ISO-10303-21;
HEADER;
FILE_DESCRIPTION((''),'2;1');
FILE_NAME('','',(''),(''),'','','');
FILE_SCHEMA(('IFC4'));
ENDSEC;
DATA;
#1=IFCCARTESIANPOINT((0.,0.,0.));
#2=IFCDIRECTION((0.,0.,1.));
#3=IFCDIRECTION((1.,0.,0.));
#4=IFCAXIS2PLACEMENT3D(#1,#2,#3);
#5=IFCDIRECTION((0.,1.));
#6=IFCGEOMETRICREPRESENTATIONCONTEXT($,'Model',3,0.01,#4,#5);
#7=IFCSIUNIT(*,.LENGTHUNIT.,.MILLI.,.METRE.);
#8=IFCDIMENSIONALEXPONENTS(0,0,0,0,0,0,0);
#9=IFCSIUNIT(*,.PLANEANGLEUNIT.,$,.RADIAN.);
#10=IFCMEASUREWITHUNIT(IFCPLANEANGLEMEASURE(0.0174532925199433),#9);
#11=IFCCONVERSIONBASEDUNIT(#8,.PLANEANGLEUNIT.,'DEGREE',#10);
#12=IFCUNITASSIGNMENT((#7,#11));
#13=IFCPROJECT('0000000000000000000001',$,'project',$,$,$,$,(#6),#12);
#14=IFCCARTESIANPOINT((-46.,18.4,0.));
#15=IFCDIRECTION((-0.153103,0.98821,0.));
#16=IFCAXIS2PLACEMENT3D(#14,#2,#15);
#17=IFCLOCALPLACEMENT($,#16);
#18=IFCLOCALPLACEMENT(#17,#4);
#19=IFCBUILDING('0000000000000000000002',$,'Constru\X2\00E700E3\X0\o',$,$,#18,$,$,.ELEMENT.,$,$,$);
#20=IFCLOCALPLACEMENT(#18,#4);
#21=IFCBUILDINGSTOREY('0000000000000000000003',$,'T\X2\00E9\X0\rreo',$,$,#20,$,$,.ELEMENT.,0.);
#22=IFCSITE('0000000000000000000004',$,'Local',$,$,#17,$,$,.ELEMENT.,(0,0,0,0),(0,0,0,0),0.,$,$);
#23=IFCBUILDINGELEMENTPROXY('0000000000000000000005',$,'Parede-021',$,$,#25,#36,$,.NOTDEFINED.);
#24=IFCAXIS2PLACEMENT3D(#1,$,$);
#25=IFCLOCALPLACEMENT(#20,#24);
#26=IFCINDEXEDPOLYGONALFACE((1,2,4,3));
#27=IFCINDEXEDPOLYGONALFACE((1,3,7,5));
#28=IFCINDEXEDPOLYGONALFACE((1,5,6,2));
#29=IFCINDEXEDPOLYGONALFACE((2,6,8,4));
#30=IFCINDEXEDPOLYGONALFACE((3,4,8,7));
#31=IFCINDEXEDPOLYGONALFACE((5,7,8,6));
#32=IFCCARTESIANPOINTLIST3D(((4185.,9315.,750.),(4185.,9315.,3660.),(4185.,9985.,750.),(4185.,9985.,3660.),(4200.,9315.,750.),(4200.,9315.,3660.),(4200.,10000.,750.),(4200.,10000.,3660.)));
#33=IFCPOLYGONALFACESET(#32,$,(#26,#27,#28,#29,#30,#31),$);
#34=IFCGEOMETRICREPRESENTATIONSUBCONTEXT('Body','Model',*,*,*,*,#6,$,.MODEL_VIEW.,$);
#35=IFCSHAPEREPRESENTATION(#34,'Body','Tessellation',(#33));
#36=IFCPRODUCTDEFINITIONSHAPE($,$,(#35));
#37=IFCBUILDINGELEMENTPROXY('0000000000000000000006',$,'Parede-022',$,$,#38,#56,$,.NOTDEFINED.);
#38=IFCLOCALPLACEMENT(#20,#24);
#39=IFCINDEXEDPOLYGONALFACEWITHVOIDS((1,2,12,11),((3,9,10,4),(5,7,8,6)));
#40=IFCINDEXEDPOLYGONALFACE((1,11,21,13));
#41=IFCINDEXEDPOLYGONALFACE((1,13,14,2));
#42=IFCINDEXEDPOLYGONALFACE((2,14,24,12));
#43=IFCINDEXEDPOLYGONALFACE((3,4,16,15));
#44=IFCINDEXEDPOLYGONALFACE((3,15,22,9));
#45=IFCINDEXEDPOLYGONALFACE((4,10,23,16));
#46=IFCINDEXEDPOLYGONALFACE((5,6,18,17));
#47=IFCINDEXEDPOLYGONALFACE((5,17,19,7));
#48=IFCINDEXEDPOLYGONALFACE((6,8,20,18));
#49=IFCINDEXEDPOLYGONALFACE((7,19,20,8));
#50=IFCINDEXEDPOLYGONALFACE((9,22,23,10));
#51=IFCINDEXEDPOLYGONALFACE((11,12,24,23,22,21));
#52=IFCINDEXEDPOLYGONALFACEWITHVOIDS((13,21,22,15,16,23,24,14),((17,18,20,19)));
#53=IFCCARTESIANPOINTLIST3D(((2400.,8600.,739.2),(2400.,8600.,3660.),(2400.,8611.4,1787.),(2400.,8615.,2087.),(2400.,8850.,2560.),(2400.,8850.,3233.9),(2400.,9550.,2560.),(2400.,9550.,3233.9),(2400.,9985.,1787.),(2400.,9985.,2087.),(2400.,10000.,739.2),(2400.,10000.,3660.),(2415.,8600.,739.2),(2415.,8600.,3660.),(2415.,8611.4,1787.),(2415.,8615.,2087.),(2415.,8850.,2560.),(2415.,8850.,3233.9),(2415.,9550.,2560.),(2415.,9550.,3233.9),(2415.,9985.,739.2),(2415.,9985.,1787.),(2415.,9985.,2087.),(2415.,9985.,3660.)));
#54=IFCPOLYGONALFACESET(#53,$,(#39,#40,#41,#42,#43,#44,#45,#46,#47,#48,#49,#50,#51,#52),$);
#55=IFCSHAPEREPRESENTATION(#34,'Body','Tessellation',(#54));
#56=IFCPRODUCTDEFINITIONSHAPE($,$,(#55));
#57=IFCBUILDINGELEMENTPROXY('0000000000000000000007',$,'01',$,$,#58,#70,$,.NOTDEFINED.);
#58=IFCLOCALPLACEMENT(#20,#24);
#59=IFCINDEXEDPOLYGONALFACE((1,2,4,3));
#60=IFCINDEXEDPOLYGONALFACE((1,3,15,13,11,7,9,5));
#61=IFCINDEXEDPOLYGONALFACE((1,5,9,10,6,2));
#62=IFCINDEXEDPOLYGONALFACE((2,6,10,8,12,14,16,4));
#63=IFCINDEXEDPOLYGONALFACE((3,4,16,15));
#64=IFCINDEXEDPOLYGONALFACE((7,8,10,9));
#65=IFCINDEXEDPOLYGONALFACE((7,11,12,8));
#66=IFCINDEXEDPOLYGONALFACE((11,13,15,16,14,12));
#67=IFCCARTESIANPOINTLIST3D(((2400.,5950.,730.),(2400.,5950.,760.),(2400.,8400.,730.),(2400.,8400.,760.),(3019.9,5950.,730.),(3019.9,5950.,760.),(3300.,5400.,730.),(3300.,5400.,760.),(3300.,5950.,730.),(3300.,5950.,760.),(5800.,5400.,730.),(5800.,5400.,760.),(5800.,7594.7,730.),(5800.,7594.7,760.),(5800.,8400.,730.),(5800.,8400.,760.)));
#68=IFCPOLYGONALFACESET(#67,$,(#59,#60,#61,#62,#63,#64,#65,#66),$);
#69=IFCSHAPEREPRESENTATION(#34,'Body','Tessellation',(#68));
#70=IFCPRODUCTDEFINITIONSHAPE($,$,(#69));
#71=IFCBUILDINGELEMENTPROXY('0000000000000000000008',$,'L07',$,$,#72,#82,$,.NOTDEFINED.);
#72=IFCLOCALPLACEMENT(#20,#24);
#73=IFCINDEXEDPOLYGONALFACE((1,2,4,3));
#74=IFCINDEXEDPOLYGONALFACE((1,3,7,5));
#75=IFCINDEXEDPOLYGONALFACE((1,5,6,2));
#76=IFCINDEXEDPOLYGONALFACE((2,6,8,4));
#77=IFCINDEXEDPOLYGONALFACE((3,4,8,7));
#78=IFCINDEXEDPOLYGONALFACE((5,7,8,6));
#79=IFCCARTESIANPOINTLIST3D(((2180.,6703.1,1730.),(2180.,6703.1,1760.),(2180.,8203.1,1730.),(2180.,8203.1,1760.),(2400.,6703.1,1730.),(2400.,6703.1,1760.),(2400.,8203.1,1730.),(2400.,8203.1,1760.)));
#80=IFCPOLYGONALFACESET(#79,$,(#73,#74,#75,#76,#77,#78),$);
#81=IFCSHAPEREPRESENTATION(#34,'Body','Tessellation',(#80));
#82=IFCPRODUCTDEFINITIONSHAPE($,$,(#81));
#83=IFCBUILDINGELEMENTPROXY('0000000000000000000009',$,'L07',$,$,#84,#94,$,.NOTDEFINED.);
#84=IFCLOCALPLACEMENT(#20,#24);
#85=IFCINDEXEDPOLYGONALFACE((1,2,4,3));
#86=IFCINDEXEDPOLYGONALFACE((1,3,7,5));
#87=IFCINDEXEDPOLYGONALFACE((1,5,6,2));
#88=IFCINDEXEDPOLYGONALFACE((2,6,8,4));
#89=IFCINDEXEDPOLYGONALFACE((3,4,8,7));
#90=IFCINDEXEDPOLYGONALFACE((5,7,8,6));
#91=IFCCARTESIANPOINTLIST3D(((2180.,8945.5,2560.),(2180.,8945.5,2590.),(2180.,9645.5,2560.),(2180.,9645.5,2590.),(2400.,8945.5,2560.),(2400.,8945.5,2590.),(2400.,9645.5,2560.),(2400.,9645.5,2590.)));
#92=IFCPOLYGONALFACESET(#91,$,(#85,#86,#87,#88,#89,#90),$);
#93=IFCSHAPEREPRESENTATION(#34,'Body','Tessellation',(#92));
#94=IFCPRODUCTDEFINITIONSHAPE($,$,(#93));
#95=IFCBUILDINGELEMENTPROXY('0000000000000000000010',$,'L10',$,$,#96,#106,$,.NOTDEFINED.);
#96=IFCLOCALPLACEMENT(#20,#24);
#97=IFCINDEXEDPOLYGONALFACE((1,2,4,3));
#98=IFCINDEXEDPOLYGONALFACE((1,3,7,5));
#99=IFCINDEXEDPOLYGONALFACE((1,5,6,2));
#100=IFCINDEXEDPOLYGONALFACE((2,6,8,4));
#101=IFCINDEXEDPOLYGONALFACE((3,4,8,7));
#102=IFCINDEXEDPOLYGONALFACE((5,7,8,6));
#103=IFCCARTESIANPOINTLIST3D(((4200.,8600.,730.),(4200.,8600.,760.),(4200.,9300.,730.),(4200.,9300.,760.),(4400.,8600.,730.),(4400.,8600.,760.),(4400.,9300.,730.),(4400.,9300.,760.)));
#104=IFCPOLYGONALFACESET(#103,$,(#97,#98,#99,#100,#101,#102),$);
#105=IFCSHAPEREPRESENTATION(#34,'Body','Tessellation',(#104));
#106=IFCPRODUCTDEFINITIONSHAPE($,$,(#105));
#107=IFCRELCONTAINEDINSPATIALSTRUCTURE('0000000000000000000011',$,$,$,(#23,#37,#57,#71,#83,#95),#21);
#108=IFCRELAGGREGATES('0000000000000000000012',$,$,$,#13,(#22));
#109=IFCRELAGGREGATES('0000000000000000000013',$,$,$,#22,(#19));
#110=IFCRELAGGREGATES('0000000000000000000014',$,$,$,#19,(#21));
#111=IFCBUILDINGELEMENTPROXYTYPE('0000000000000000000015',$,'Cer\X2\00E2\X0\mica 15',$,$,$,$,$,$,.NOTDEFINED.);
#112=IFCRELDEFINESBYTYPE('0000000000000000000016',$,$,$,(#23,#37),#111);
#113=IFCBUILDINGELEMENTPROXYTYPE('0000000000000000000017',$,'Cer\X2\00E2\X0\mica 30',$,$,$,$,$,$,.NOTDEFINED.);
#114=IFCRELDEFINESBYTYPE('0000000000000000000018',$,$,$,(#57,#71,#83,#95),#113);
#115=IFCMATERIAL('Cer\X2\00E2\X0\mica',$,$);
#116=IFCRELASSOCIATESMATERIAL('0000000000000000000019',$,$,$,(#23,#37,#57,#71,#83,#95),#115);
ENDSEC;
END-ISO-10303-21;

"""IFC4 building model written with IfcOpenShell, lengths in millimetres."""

from ifc_helpers import new_model, entity, si_unit, converted_unit, direction, frame, origin_with_axes, origin_2d_with_axis, place, context, subcontext, project, spatial, line, indexed_curve, rectangle, outline, extrude, material, type_object, element, save


model = new_model("IFC4")

# Units and contexts
model_context = context("Model", 3, precision=0.01, world=origin_with_axes(), true_north=direction((0.0, 1.0)))
body_context = subcontext(model_context, "Body", "Model", "MODEL_VIEW")
ifc_project = project(units=[si_unit("LENGTHUNIT", "METRE", prefix="MILLI"), converted_unit("PLANEANGLEUNIT", "DEGREE", entity("IfcPlaneAngleMeasure", 0.0174532925199433), si_unit("PLANEANGLEUNIT", "RADIAN"), dimensions=[0, 0, 0, 0, 0, 0, 0])], contexts=[model_context])

# Site, building, storey
site_placement = place(None, frame((-46.0, 18.4, 0.0), z_axis=(0.0, 0.0, 1.0), x_axis=(-0.153103, 0.98821, 0.0)))
site = spatial("IfcSite", under=ifc_project, at=site_placement, Name="Local", CompositionType="ELEMENT", RefLatitude=(0, 0, 0, 0), RefLongitude=(0, 0, 0, 0), RefElevation=0.0)
building_placement = place(site_placement, origin_with_axes())
building = spatial("IfcBuilding", under=site, at=building_placement, Name="Construção", CompositionType="ELEMENT")
storey_placement = place(building_placement, origin_with_axes())
storey = spatial("IfcBuildingStorey", under=building, at=storey_placement, Name="Térreo", CompositionType="ELEMENT", Elevation=0.0)

# Building element proxy
ifc_material_1 = material(Name="Cerâmica")
building_element_proxy_type_1 = type_object("IfcBuildingElementProxyType", Name="Cerâmica 15", PredefinedType="NOTDEFINED")
proxy_1_placement = place(storey_placement, frame((4200.0, 9315.0, 750.0), z_axis=(0.0, 0.0, 1.0), x_axis=(-0.000002, 1.0, 0.0)))
element("IfcBuildingElementProxy", 1, at=proxy_1_placement, inside=storey, type_object=building_element_proxy_type_1, material=ifc_material_1, Name="Parede-021", PredefinedType="NOTDEFINED", context=body_context, shape_type="SweptSolid", body=[
    extrude(outline(indexed_curve([(0.0, 0.0), (685.0, 0.0), (670.0, 15.0), (0.0, 15.0)], segments=[line(1, 2, 3, 4, 1)])), origin_with_axes(), (0.0, 0.0, 1.0), 2910.0),
])

# Building element proxy, openings
proxy_2_placement = place(storey_placement, frame((2400.0, 10000.0, 739.2), z_axis=(0.0, 0.0, 1.0), x_axis=(0.0, -1.0, 0.0)))
proxy_2 = element("IfcBuildingElementProxy", 2, at=proxy_2_placement, inside=storey, type_object=building_element_proxy_type_1, material=ifc_material_1, Name="Parede-022", PredefinedType="NOTDEFINED", context=body_context, shape_type="SweptSolid", body=[
    extrude(outline(indexed_curve([(0.0, 0.0), (1400.0, 0.0), (1400.0, 15.0), (15.0, 15.0)], segments=[line(1, 2, 3, 4, 1)])), origin_with_axes(), (0.0, 0.0, 1.0), 2920.8),
])
opening_1_placement = place(proxy_2_placement, frame((10000.0, -2400.0, -739.2), z_axis=(0.0, 0.0, 1.0), x_axis=(0.0, 1.0, 0.0)))
element("IfcOpeningElement", 3, at=opening_1_placement, cuts=proxy_2, PredefinedType="OPENING", context=body_context, shape_type="SweptSolid", body=[
    extrude(outline(indexed_curve([(-686.8, -150.0), (686.8, -150.0), (683.2, 150.0), (-686.8, 150.0)], segments=[line(1, 2, 3, 4, 1)])), frame((2385.0, 9298.2, 1937.0), z_axis=(-1.0, 0.0, 0.0), x_axis=(0.0, -1.0, 0.0)), (0.0, 0.0, -1.0), 45.0),
])
opening_2_placement = place(proxy_2_placement, frame((10000.0, -2400.0, -739.2), z_axis=(0.0, 0.0, 1.0), x_axis=(0.0, 1.0, 0.0)))
element("IfcOpeningElement", 4, at=opening_2_placement, cuts=proxy_2, PredefinedType="OPENING", context=body_context, shape_type="SweptSolid", body=[
    extrude(rectangle(XDim=700.0, YDim=673.9, at=origin_2d_with_axis()), frame((2385.0, 9200.0, 2897.0), z_axis=(-1.0, 0.0, 0.0), x_axis=(0.0, -1.0, 0.0)), (0.0, 0.0, -1.0), 45.0),
])

# Building element proxies
building_element_proxy_type_2 = type_object("IfcBuildingElementProxyType", Name="Cerâmica 30", PredefinedType="NOTDEFINED")
proxy_3_placement = place(storey_placement, frame((2400.0, 5950.0, 760.0), z_axis=(0.0, 0.0, 1.0), x_axis=(1.0, 0.0, 0.0)))
element("IfcBuildingElementProxy", 5, at=proxy_3_placement, inside=storey, type_object=building_element_proxy_type_2, material=ifc_material_1, Name="01", PredefinedType="NOTDEFINED", context=body_context, shape_type="SweptSolid", body=[
    extrude(outline(indexed_curve([(0.0, 0.0), (619.9, 0.0), (900.0, 0.0), (900.0, -550.0), (3400.0, -550.0), (3400.0, 1644.7), (3400.0, 2450.0), (0.0, 2450.0)], segments=[line(1, 2, 3, 4, 5, 6, 7, 8, 1)])), frame((0.0, 0.0, -30.0), z_axis=(0.0, 0.0, 1.0), x_axis=(1.0, 0.0, 0.0)), (0.0, 0.0, 1.0), 30.0),
])
proxy_4_placement = place(storey_placement, frame((2180.0, 6703.1, 1760.0), z_axis=(0.0, 0.0, 1.0), x_axis=(1.0, 0.0, 0.0)))
element("IfcBuildingElementProxy", 6, at=proxy_4_placement, inside=storey, type_object=building_element_proxy_type_2, material=ifc_material_1, Name="L07", PredefinedType="NOTDEFINED", context=body_context, shape_type="SweptSolid", body=[
    extrude(outline(indexed_curve([(0.0, 0.0), (220.0, 0.0), (220.0, 1500.0), (0.0, 1500.0)], segments=[line(1, 2, 3, 4, 1)])), frame((0.0, 0.0, -30.0), z_axis=(0.0, 0.0, 1.0), x_axis=(1.0, 0.0, 0.0)), (0.0, 0.0, 1.0), 30.0),
])
proxy_5_placement = place(storey_placement, frame((2180.0, 8945.5, 2590.0), z_axis=(0.0, 0.0, 1.0), x_axis=(1.0, 0.0, 0.0)))
element("IfcBuildingElementProxy", 7, at=proxy_5_placement, inside=storey, type_object=building_element_proxy_type_2, material=ifc_material_1, Name="L07", PredefinedType="NOTDEFINED", context=body_context, shape_type="SweptSolid", body=[
    extrude(outline(indexed_curve([(0.0, 0.0), (220.0, 0.0), (220.0, 700.0), (0.0, 700.0)], segments=[line(1, 2, 3, 4, 1)])), frame((0.0, 0.0, -30.0), z_axis=(0.0, 0.0, 1.0), x_axis=(1.0, 0.0, 0.0)), (0.0, 0.0, 1.0), 30.0),
])
proxy_6_placement = place(storey_placement, frame((4200.0, 8600.0, 760.0), z_axis=(0.0, 0.0, 1.0), x_axis=(1.0, 0.0, 0.0)))
element("IfcBuildingElementProxy", 8, at=proxy_6_placement, inside=storey, type_object=building_element_proxy_type_2, material=ifc_material_1, Name="L10", PredefinedType="NOTDEFINED", context=body_context, shape_type="SweptSolid", body=[
    extrude(outline(indexed_curve([(0.0, 0.0), (200.0, 0.0), (200.0, 700.0), (0.0, 700.0)], segments=[line(1, 2, 3, 4, 1)])), frame((0.0, 0.0, -30.0), z_axis=(0.0, 0.0, 1.0), x_axis=(1.0, 0.0, 0.0)), (0.0, 0.0, 1.0), 30.0),
])

save(model, "model.ifc")
